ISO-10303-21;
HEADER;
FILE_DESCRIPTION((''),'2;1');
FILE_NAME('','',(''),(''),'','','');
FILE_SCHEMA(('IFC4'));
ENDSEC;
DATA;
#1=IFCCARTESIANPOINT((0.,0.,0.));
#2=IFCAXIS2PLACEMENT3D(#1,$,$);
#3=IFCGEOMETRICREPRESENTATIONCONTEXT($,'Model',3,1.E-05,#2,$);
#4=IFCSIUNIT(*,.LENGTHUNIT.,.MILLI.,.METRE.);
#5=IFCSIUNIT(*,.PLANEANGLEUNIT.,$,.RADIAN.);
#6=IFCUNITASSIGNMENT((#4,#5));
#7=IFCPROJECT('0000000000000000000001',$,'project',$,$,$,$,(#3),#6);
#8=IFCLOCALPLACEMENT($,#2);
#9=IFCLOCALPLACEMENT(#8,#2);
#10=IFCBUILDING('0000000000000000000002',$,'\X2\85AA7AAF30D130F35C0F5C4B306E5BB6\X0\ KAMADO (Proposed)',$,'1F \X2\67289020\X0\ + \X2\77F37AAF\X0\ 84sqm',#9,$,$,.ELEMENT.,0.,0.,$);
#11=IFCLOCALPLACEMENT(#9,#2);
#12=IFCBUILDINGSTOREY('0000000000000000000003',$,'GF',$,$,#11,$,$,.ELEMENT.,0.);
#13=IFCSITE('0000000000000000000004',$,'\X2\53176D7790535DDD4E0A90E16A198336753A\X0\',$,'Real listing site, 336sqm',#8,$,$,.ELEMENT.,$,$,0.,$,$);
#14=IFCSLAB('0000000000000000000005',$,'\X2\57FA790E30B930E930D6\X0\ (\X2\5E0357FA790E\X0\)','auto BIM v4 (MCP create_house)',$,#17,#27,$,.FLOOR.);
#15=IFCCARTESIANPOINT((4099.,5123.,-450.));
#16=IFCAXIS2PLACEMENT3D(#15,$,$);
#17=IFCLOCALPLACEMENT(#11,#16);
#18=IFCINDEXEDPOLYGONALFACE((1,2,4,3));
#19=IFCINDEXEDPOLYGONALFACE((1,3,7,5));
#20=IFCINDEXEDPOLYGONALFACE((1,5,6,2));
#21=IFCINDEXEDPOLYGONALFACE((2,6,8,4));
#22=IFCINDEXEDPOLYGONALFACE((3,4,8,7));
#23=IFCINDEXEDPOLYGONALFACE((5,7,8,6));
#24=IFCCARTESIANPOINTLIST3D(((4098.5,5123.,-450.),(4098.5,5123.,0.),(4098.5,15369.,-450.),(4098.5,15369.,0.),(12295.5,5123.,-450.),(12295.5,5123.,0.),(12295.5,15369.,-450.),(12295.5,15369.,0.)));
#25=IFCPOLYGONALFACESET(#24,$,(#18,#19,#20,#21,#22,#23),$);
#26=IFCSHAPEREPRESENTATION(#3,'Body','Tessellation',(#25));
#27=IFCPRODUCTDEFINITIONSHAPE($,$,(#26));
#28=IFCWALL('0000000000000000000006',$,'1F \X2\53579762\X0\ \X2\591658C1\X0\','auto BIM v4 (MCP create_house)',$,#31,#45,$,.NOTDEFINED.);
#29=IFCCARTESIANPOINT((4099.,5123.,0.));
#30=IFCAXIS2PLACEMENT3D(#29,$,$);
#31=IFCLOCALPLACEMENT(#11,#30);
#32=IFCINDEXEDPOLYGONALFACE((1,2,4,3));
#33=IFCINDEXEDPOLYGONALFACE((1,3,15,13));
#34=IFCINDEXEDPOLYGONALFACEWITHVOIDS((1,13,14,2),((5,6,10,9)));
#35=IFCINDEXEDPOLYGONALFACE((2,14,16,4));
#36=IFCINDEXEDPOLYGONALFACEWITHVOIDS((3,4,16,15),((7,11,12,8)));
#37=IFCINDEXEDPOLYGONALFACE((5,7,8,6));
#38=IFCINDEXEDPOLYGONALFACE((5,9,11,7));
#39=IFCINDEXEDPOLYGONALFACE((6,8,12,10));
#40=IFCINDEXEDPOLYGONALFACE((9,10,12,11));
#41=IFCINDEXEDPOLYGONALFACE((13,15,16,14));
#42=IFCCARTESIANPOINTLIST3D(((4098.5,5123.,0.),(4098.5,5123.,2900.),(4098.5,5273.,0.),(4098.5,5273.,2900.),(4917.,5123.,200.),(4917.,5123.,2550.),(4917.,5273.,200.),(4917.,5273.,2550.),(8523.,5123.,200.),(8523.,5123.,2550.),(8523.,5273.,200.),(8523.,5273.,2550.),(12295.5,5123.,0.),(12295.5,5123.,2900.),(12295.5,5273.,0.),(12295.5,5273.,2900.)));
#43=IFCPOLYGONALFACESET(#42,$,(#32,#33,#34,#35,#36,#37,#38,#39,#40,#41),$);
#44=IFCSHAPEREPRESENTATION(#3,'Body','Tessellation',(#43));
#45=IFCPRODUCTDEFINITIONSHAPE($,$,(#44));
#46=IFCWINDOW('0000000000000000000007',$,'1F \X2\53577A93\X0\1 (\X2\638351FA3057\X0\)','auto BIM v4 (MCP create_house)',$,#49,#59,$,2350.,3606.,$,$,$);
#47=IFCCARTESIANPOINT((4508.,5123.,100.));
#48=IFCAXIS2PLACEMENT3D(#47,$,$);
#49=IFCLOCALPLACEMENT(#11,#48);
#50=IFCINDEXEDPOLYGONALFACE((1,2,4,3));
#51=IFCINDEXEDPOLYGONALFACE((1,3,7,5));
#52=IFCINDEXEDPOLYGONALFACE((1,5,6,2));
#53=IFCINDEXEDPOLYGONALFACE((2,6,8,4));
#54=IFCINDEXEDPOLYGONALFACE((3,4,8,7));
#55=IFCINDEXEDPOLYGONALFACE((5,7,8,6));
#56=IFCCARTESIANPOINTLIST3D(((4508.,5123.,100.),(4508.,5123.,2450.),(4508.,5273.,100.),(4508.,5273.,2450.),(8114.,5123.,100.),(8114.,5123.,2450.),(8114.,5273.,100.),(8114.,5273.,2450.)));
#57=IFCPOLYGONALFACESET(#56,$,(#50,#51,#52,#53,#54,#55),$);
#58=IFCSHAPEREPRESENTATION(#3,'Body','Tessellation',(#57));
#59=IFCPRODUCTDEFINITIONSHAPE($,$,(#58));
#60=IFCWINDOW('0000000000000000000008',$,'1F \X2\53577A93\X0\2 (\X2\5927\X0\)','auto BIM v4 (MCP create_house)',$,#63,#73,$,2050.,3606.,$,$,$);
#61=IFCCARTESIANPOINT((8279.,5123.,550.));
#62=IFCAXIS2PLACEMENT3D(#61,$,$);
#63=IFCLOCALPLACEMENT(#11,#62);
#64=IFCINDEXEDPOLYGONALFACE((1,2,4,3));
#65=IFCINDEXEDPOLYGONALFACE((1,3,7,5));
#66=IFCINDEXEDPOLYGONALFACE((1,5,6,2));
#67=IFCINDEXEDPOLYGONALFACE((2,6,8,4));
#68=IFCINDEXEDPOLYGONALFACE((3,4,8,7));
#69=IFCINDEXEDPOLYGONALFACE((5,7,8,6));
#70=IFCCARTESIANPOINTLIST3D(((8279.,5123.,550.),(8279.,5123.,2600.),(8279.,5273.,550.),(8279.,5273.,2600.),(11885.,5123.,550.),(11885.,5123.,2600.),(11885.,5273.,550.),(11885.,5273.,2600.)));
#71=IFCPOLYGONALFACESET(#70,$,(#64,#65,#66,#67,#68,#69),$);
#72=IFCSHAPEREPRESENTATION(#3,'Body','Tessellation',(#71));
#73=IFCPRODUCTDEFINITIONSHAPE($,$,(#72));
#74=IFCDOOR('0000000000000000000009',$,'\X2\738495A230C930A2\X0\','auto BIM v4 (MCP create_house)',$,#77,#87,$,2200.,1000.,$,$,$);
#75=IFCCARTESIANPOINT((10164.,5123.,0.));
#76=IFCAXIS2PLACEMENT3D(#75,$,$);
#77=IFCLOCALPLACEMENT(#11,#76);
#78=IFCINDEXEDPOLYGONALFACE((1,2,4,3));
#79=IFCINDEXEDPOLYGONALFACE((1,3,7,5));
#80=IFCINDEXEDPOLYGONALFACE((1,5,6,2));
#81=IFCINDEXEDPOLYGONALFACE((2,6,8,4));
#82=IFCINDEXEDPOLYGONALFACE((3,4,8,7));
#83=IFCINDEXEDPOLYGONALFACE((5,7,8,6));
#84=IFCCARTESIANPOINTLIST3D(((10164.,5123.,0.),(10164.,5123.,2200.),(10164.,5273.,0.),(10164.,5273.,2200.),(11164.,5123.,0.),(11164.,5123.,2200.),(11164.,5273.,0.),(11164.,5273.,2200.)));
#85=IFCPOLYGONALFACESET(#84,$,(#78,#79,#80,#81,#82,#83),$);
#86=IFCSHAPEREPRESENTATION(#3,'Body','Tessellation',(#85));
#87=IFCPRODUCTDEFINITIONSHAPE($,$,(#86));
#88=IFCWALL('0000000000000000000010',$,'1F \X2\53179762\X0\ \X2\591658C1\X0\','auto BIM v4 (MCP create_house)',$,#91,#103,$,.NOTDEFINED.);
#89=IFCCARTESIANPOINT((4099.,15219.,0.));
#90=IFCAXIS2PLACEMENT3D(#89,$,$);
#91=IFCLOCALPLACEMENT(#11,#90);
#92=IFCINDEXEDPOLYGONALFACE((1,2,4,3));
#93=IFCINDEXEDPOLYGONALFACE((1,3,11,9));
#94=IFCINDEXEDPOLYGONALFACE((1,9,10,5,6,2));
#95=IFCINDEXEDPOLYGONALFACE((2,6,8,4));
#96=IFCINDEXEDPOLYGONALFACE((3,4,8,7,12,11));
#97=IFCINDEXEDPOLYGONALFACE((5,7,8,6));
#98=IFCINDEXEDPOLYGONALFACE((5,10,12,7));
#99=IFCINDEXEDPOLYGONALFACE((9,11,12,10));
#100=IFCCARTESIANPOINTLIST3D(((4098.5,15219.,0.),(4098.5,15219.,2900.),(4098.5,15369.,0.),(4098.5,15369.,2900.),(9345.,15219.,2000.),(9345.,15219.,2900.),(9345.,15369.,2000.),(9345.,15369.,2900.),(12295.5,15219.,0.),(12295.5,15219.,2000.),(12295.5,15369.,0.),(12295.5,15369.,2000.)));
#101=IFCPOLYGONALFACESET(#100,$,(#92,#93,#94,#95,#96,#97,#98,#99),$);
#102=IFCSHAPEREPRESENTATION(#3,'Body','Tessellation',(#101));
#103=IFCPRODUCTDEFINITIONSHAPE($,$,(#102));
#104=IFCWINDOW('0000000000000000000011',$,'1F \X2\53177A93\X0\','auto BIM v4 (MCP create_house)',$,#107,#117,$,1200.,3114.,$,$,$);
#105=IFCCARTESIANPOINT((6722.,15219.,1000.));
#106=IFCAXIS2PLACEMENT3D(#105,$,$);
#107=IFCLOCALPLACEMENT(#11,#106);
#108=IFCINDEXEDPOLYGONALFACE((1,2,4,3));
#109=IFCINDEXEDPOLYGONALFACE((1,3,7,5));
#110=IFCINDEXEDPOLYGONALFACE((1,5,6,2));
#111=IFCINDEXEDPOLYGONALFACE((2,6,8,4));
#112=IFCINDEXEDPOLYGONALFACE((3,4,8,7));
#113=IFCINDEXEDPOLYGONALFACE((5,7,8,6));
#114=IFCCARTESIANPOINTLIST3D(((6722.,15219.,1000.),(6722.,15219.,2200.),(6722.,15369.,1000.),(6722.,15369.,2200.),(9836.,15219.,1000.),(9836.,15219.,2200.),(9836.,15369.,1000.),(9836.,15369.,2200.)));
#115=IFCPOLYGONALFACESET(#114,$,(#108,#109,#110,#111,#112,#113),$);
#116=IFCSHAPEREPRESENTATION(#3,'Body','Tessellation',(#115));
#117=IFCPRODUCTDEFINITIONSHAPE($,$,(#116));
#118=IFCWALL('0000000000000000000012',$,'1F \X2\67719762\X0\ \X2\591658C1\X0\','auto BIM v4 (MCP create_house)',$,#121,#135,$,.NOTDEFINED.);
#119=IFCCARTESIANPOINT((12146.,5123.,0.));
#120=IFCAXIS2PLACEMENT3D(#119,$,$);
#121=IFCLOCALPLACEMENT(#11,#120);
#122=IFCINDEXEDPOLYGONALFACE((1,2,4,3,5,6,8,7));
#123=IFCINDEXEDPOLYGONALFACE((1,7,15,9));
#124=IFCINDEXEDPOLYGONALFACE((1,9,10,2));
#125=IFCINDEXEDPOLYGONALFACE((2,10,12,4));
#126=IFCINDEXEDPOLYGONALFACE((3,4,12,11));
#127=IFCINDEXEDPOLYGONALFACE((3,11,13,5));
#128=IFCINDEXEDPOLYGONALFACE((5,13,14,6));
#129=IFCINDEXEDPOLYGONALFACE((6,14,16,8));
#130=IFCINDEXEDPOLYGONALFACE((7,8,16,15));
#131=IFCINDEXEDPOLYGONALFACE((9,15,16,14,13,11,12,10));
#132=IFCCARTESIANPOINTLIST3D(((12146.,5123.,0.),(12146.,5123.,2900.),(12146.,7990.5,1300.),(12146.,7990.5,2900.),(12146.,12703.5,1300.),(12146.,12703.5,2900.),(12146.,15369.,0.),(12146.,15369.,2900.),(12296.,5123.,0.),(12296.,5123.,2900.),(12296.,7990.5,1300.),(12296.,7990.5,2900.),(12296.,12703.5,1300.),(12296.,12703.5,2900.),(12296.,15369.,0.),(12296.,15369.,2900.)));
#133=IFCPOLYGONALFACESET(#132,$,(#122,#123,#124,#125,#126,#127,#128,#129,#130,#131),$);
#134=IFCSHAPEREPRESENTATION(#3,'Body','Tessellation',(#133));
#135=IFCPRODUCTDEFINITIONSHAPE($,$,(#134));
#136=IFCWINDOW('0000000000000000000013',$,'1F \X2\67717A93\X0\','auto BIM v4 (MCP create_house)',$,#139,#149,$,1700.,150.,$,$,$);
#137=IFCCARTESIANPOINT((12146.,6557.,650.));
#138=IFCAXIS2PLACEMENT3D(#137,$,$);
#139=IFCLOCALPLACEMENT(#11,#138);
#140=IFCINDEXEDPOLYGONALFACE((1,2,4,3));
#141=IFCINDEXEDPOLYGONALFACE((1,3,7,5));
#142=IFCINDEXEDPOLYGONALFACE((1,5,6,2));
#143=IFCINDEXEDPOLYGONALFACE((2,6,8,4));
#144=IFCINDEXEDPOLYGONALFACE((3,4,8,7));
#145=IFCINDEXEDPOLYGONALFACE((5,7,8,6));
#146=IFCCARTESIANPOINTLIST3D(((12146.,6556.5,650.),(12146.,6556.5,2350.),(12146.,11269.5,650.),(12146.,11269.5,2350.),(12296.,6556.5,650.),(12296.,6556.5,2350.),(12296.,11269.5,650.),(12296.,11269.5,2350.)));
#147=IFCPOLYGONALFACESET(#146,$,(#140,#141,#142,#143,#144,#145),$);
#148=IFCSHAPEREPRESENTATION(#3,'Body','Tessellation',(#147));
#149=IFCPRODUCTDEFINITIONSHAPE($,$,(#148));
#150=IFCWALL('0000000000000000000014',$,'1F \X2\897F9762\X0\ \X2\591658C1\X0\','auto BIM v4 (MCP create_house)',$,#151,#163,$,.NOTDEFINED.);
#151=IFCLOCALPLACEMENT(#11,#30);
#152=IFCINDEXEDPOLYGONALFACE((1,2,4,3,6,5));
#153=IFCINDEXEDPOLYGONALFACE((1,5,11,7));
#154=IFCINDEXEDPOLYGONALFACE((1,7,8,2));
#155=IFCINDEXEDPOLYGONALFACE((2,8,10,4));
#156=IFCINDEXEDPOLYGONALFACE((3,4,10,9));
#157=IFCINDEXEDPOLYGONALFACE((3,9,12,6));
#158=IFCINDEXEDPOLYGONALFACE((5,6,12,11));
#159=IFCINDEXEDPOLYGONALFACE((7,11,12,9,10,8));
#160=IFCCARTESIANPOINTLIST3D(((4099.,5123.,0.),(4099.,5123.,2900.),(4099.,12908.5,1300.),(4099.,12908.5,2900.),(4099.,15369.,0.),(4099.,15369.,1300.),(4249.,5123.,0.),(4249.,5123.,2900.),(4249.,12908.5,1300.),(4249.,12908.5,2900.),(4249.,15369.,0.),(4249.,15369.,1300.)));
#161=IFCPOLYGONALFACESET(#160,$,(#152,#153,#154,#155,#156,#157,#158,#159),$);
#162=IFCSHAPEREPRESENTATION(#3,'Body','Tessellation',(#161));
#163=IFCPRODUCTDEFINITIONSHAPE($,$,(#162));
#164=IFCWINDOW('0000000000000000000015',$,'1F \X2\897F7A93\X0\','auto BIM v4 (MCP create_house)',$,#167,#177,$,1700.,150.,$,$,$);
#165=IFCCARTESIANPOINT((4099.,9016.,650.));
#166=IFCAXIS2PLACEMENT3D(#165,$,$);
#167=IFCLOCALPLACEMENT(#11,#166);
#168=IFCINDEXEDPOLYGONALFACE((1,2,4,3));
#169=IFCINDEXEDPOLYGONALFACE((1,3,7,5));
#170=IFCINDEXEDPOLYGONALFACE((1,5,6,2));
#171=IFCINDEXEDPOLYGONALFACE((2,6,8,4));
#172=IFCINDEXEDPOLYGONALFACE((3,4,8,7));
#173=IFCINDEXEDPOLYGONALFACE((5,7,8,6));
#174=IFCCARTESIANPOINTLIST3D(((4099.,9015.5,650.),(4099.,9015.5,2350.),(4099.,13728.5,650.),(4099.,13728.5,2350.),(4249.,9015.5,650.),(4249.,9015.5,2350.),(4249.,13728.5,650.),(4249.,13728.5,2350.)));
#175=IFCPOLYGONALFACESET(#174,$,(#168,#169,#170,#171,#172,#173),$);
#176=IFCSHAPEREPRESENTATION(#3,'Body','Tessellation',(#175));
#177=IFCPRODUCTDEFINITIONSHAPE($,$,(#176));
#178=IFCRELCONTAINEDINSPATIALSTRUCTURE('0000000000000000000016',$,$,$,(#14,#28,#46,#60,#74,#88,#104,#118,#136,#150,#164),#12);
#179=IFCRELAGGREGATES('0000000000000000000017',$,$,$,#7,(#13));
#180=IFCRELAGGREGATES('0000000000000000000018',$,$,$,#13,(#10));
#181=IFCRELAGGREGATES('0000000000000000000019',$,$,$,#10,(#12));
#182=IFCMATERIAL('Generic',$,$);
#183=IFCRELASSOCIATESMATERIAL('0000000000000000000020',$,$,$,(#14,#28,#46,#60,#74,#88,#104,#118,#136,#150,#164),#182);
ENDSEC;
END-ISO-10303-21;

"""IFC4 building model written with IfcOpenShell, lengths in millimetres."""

from ifc_helpers import new_model, si_unit, frame, frame_2d, origin, place, context, project, spatial, rectangle, extrude, material, element, fill, save


model = new_model("IFC4")

# Units and contexts
model_context = context("Model", 3, precision=1e-05, world=origin())
ifc_project = project(units=[si_unit("LENGTHUNIT", "METRE", prefix="MILLI"), si_unit("PLANEANGLEUNIT", "RADIAN")], contexts=[model_context])

# Site, building, storey
site_placement = place(None, origin())
site = spatial("IfcSite", under=ifc_project, at=site_placement, Name="北海道川上郡標茶町", ObjectType="Real listing site, 336sqm", CompositionType="ELEMENT", RefElevation=0.0)
building_placement = place(site_placement, origin())
building = spatial("IfcBuilding", under=site, at=building_placement, Name="薪窯パン小屋の家 KAMADO (Proposed)", ObjectType="1F 木造 + 石窯 84sqm", CompositionType="ELEMENT", ElevationOfRefHeight=0.0, ElevationOfTerrain=0.0)
storey_placement = place(building_placement, origin())
storey = spatial("IfcBuildingStorey", under=building, at=storey_placement, Name="GF", CompositionType="ELEMENT", Elevation=0.0)

# Slab
ifc_material = material(Name="Generic")
slab_1_placement = place(storey_placement, frame((4099.0, 5123.0, -450.0)))
element("IfcSlab", 1, at=slab_1_placement, inside=storey, material=ifc_material, Name="基礎スラブ (布基礎)", Description="auto BIM v4 (MCP create_house)", PredefinedType="FLOOR", context=model_context, shape_type="SweptSolid", body=[
    extrude(rectangle(XDim=8197.0, YDim=10246.0, at=frame_2d((4098.0, 5123.0))), frame((4099.0, 5123.0, -450.0)), (0.0, 0.0, 1.0), 450.0),
])

# Wall, openings, windows, door
wall_1_placement = place(storey_placement, frame((4099.0, 5123.0, 0.0)))
wall_1 = element("IfcWall", 2, at=wall_1_placement, inside=storey, material=ifc_material, Name="1F 南面 外壁", Description="auto BIM v4 (MCP create_house)", PredefinedType="NOTDEFINED", context=model_context, shape_type="SweptSolid", body=[
    extrude(rectangle(XDim=8197.0, YDim=150.0, at=frame_2d((4098.0, 75.0))), frame((4099.0, 5123.0, 0.0)), (0.0, 0.0, 1.0), 2900.0),
])
opening_1_placement = place(storey_placement, frame((4508.0, 5123.0, 100.0)))
opening_1 = element("IfcOpeningElement", 3, at=opening_1_placement, cuts=wall_1, PredefinedType="NOTDEFINED", context=model_context, shape_type="SweptSolid", body=[
    extrude(rectangle(XDim=3606.0, YDim=150.0, at=frame_2d((1803.0, 75.0))), frame((4508.0, 5123.0, 100.0)), (0.0, 0.0, 1.0), 2350.0),
])
opening_2_placement = place(storey_placement, frame((8279.0, 5123.0, 550.0)))
opening_2 = element("IfcOpeningElement", 4, at=opening_2_placement, cuts=wall_1, PredefinedType="NOTDEFINED", context=model_context, shape_type="SweptSolid", body=[
    extrude(rectangle(XDim=3606.0, YDim=150.0, at=frame_2d((1803.0, 75.0))), frame((8279.0, 5123.0, 550.0)), (0.0, 0.0, 1.0), 2050.0),
])
opening_3_placement = place(storey_placement, frame((10164.0, 5123.0, 0.0)))
opening_3 = element("IfcOpeningElement", 5, at=opening_3_placement, cuts=wall_1, PredefinedType="NOTDEFINED", context=model_context, shape_type="SweptSolid", body=[
    extrude(rectangle(XDim=1000.0, YDim=150.0, at=frame_2d((500.0, 75.0))), frame((10164.0, 5123.0, 0.0)), (0.0, 0.0, 1.0), 2200.0),
])
window_1_placement = place(storey_placement, frame((4508.0, 5123.0, 100.0)))
window_1 = element("IfcWindow", 6, at=window_1_placement, inside=storey, material=ifc_material, Name="1F 南窓1 (掃出し)", Description="auto BIM v4 (MCP create_house)", OverallHeight=2350.0, OverallWidth=3606.0, context=model_context, shape_type="SweptSolid", body=[
    extrude(rectangle(XDim=3606.0, YDim=150.0, at=frame_2d((1803.0, 75.0))), frame((4508.0, 5123.0, 100.0)), (0.0, 0.0, 1.0), 2350.0),
])
fill(opening_1, window_1)
window_2_placement = place(storey_placement, frame((8279.0, 5123.0, 550.0)))
window_2 = element("IfcWindow", 7, at=window_2_placement, inside=storey, material=ifc_material, Name="1F 南窓2 (大)", Description="auto BIM v4 (MCP create_house)", OverallHeight=2050.0, OverallWidth=3606.0, context=model_context, shape_type="SweptSolid", body=[
    extrude(rectangle(XDim=3606.0, YDim=150.0, at=frame_2d((1803.0, 75.0))), frame((8279.0, 5123.0, 550.0)), (0.0, 0.0, 1.0), 2050.0),
])
fill(opening_2, window_2)
door_placement = place(storey_placement, frame((10164.0, 5123.0, 0.0)))
door = element("IfcDoor", 8, at=door_placement, inside=storey, material=ifc_material, Name="玄関ドア", Description="auto BIM v4 (MCP create_house)", OverallHeight=2200.0, OverallWidth=1000.0, context=model_context, shape_type="SweptSolid", body=[
    extrude(rectangle(XDim=1000.0, YDim=150.0, at=frame_2d((500.0, 75.0))), frame((10164.0, 5123.0, 0.0)), (0.0, 0.0, 1.0), 2200.0),
])
fill(opening_3, door)

# Walls, openings, windows
wall_2_placement = place(storey_placement, frame((4099.0, 15219.0, 0.0)))
wall_2 = element("IfcWall", 9, at=wall_2_placement, inside=storey, material=ifc_material, Name="1F 北面 外壁", Description="auto BIM v4 (MCP create_house)", PredefinedType="NOTDEFINED", context=model_context, shape_type="SweptSolid", body=[
    extrude(rectangle(XDim=8197.0, YDim=150.0, at=frame_2d((4098.0, 75.0))), frame((4099.0, 15219.0, 0.0)), (0.0, 0.0, 1.0), 2900.0),
])
opening_4_placement = place(storey_placement, frame((6722.0, 15219.0, 1000.0)))
opening_4 = element("IfcOpeningElement", 10, at=opening_4_placement, cuts=wall_2, PredefinedType="NOTDEFINED", context=model_context, shape_type="SweptSolid", body=[
    extrude(rectangle(XDim=3114.0, YDim=150.0, at=frame_2d((1557.0, 75.0))), frame((6722.0, 15219.0, 1000.0)), (0.0, 0.0, 1.0), 1200.0),
])
window_3_placement = place(storey_placement, frame((6722.0, 15219.0, 1000.0)))
window_3 = element("IfcWindow", 11, at=window_3_placement, inside=storey, material=ifc_material, Name="1F 北窓", Description="auto BIM v4 (MCP create_house)", OverallHeight=1200.0, OverallWidth=3114.0, context=model_context, shape_type="SweptSolid", body=[
    extrude(rectangle(XDim=3114.0, YDim=150.0, at=frame_2d((1557.0, 75.0))), frame((6722.0, 15219.0, 1000.0)), (0.0, 0.0, 1.0), 1200.0),
])
fill(opening_4, window_3)
wall_3_placement = place(storey_placement, frame((12146.0, 5123.0, 0.0)))
wall_3 = element("IfcWall", 12, at=wall_3_placement, inside=storey, material=ifc_material, Name="1F 東面 外壁", Description="auto BIM v4 (MCP create_house)", PredefinedType="NOTDEFINED", context=model_context, shape_type="SweptSolid", body=[
    extrude(rectangle(XDim=150.0, YDim=10246.0, at=frame_2d((75.0, 5123.0))), frame((12146.0, 5123.0, 0.0)), (0.0, 0.0, 1.0), 2900.0),
])
opening_5_placement = place(storey_placement, frame((12146.0, 6557.0, 650.0)))
opening_5 = element("IfcOpeningElement", 13, at=opening_5_placement, cuts=wall_3, PredefinedType="NOTDEFINED", context=model_context, shape_type="SweptSolid", body=[
    extrude(rectangle(XDim=150.0, YDim=4713.0, at=frame_2d((75.0, 2356.0))), frame((12146.0, 6557.0, 650.0)), (0.0, 0.0, 1.0), 1700.0),
])
window_4_placement = place(storey_placement, frame((12146.0, 6557.0, 650.0)))
window_4 = element("IfcWindow", 14, at=window_4_placement, inside=storey, material=ifc_material, Name="1F 東窓", Description="auto BIM v4 (MCP create_house)", OverallHeight=1700.0, OverallWidth=150.0, context=model_context, shape_type="SweptSolid", body=[
    extrude(rectangle(XDim=150.0, YDim=4713.0, at=frame_2d((75.0, 2356.0))), frame((12146.0, 6557.0, 650.0)), (0.0, 0.0, 1.0), 1700.0),
])
fill(opening_5, window_4)
wall_4_placement = place(storey_placement, frame((4099.0, 5123.0, 0.0)))
wall_4 = element("IfcWall", 15, at=wall_4_placement, inside=storey, material=ifc_material, Name="1F 西面 外壁", Description="auto BIM v4 (MCP create_house)", PredefinedType="NOTDEFINED", context=model_context, shape_type="SweptSolid", body=[
    extrude(rectangle(XDim=150.0, YDim=10246.0, at=frame_2d((75.0, 5123.0))), frame((4099.0, 5123.0, 0.0)), (0.0, 0.0, 1.0), 2900.0),
])
opening_6_placement = place(storey_placement, frame((4099.0, 9016.0, 650.0)))
opening_6 = element("IfcOpeningElement", 16, at=opening_6_placement, cuts=wall_4, PredefinedType="NOTDEFINED", context=model_context, shape_type="SweptSolid", body=[
    extrude(rectangle(XDim=150.0, YDim=4713.0, at=frame_2d((75.0, 2356.0))), frame((4099.0, 9016.0, 650.0)), (0.0, 0.0, 1.0), 1700.0),
])
window_5_placement = place(storey_placement, frame((4099.0, 9016.0, 650.0)))
window_5 = element("IfcWindow", 17, at=window_5_placement, inside=storey, material=ifc_material, Name="1F 西窓", Description="auto BIM v4 (MCP create_house)", OverallHeight=1700.0, OverallWidth=150.0, context=model_context, shape_type="SweptSolid", body=[
    extrude(rectangle(XDim=150.0, YDim=4713.0, at=frame_2d((75.0, 2356.0))), frame((4099.0, 9016.0, 650.0)), (0.0, 0.0, 1.0), 1700.0),
])
fill(opening_6, window_5)

save(model, "model.ifc")
